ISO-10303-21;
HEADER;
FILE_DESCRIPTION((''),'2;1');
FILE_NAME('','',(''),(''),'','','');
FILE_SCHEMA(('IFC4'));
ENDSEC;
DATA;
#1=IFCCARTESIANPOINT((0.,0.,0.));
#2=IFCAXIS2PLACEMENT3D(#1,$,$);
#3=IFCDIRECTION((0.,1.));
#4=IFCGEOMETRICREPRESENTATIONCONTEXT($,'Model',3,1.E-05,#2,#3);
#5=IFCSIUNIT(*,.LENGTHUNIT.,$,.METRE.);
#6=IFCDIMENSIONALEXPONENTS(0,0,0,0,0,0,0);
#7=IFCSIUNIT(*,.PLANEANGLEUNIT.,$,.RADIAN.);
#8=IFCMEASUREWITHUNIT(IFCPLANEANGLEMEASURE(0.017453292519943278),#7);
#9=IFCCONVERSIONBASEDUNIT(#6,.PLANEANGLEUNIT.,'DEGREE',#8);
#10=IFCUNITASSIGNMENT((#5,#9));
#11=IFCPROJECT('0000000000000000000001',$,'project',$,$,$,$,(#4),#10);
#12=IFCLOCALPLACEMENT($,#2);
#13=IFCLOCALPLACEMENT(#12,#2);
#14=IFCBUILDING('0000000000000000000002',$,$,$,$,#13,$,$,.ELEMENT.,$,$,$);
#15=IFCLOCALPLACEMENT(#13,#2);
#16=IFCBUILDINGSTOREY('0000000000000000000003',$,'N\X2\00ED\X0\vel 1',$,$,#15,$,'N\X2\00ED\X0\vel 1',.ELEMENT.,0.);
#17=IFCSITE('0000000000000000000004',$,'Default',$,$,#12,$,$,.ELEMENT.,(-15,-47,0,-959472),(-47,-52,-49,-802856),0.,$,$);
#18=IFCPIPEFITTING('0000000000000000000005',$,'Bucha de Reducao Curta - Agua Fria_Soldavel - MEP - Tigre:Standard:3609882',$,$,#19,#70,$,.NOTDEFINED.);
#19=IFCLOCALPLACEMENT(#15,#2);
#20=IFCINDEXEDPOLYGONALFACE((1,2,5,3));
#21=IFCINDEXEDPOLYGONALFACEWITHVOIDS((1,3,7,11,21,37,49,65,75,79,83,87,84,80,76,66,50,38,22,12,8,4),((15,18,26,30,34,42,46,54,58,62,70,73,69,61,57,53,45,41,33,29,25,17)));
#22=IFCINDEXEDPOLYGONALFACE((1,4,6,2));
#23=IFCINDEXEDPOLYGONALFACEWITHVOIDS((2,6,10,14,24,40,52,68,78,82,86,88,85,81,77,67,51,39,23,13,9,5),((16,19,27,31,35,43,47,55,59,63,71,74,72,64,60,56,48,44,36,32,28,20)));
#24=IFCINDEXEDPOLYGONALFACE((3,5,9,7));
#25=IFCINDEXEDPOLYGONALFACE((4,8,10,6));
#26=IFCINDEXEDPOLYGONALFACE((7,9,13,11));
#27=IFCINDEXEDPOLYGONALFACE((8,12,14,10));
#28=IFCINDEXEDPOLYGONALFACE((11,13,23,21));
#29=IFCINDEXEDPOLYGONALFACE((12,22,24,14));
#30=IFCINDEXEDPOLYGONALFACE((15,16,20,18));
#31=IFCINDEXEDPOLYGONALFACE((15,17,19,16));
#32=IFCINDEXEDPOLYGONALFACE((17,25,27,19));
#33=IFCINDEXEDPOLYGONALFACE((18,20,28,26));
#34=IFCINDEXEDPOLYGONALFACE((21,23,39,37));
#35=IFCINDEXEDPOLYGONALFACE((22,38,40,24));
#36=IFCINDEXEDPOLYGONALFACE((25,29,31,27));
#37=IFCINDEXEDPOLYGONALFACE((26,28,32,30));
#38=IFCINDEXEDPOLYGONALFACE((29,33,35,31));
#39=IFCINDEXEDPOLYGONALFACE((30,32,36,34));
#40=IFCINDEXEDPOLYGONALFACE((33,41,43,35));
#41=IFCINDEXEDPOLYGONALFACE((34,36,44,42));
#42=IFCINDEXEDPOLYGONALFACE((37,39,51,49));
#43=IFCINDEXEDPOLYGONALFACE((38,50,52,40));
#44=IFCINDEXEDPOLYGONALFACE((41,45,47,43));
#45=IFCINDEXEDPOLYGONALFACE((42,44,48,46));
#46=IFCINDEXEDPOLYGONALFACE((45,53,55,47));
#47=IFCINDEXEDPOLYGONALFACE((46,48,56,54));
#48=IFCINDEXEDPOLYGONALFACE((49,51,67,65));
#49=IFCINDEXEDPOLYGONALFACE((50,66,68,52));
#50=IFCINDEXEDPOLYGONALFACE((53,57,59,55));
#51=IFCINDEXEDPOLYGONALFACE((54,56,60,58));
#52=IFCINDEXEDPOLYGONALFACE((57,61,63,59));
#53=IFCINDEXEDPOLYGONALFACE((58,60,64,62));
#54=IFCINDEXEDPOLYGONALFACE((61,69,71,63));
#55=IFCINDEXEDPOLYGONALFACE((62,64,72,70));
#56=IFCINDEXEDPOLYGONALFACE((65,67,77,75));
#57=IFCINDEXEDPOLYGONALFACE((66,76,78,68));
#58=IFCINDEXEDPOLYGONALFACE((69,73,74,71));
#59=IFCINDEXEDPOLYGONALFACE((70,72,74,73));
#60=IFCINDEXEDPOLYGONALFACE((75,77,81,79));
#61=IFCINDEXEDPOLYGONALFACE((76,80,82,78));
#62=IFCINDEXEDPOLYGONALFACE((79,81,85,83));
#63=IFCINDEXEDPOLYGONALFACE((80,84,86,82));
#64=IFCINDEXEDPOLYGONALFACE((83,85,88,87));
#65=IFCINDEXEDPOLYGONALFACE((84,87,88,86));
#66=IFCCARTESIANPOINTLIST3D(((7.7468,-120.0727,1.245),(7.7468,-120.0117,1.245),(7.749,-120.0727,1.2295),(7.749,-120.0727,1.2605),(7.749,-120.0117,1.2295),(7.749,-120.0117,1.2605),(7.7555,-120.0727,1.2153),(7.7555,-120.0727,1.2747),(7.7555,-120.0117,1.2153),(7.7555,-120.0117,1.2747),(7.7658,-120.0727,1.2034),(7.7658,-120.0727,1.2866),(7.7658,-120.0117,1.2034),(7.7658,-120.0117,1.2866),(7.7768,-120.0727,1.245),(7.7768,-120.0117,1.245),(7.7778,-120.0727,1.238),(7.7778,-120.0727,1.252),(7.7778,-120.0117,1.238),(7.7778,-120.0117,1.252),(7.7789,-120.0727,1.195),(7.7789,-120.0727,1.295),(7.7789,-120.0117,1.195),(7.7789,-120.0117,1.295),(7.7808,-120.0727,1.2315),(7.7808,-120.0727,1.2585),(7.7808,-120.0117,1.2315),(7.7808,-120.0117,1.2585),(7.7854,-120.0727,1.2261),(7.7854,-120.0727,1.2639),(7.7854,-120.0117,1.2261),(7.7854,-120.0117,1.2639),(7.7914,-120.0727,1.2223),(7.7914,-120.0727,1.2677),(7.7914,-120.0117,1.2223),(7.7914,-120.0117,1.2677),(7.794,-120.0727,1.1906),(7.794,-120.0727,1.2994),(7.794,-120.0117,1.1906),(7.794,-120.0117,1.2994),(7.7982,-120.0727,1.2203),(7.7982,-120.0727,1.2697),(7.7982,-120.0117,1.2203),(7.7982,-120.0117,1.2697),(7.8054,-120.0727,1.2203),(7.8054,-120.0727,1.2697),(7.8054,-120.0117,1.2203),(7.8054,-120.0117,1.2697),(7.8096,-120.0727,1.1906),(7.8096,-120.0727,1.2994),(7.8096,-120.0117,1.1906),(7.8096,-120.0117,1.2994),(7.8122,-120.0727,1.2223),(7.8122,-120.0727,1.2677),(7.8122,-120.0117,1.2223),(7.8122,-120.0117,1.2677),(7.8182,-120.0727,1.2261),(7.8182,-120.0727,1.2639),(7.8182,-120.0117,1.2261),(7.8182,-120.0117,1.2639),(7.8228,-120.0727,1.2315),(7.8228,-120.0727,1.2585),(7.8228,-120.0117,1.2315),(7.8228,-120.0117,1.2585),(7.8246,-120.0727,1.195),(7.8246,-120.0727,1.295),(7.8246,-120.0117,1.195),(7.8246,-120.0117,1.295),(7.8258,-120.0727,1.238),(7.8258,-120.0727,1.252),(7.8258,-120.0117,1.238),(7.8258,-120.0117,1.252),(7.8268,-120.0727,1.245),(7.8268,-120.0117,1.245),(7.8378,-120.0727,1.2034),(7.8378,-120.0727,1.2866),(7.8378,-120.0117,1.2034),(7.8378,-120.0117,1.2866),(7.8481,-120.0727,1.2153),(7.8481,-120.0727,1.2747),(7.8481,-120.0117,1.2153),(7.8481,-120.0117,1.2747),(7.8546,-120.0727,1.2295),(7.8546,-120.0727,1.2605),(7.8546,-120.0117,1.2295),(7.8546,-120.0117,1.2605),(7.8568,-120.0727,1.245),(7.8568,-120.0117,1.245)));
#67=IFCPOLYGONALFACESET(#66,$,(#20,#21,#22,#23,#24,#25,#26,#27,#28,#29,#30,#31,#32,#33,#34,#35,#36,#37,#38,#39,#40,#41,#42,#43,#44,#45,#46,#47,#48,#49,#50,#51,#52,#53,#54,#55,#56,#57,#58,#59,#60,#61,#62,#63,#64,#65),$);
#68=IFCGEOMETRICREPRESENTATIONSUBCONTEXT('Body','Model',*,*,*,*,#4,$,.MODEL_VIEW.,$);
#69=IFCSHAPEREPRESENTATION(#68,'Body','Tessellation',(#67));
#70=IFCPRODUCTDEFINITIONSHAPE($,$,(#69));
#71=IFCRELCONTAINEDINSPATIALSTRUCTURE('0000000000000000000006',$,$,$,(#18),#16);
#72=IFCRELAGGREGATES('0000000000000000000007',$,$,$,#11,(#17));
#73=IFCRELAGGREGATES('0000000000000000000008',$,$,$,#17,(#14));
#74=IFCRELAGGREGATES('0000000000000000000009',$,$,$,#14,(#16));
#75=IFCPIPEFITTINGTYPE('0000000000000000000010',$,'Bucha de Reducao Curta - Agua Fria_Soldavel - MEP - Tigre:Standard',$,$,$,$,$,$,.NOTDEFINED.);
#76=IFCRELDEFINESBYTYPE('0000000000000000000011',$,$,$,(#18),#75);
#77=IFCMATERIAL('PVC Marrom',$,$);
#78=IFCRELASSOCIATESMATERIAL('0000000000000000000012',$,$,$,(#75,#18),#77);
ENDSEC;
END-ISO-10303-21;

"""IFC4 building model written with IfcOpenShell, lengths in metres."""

from ifc_helpers import new_model, entity, si_unit, converted_unit, direction, frame, origin, place, context, subcontext, project, spatial, arc, indexed_curve, outline, extrude, source, transform, mapped, material, type_object, type_shapes, element, save


model = new_model("IFC4")

# Units and contexts
model_context = context("Model", 3, precision=1e-05, world=origin(), true_north=direction((0.0, 1.0)))
body_context = subcontext(model_context, "Body", "Model", "MODEL_VIEW")
ifc_project = project(units=[si_unit("LENGTHUNIT", "METRE"), converted_unit("PLANEANGLEUNIT", "DEGREE", entity("IfcPlaneAngleMeasure", 0.017453292519943278), si_unit("PLANEANGLEUNIT", "RADIAN"), dimensions=[0, 0, 0, 0, 0, 0, 0])], contexts=[model_context])

# Site, building, storey
site_placement = place(None, origin())
site = spatial("IfcSite", under=ifc_project, at=site_placement, Name="Default", CompositionType="ELEMENT", RefLatitude=(-15, -47, 0, -959472), RefLongitude=(-47, -52, -49, -802856), RefElevation=0.0)
building_placement = place(site_placement, origin())
building = spatial("IfcBuilding", under=site, at=building_placement, CompositionType="ELEMENT")
storey_placement = place(building_placement, origin())
storey = spatial("IfcBuildingStorey", under=building, at=storey_placement, Name="Nível 1", LongName="Nível 1", CompositionType="ELEMENT", Elevation=0.0)

# Pipe fitting
ifc_material_1 = material(Name="PVC Marrom")
pipe_fitting_type_1 = type_object("IfcPipeFittingType", Name="Bucha de Reducao Curta - Agua Fria_Soldavel - MEP - Tigre:Standard", PredefinedType="NOTDEFINED", material=ifc_material_1)
shared_shape_1 = source(origin(), body_context, "Body", "SweptSolid", [
    extrude(outline(indexed_curve([(-0.055, 0.0), (0.0, -0.055), (0.055, 0.0), (0.0, 0.055)], segments=[arc(1, 2, 3), arc(3, 4, 1)], self_intersect=False), holes=[indexed_curve([(-0.025, 0.0), (0.0, 0.025), (0.025, 0.0), (0.0, -0.025)], segments=[arc(1, 2, 3), arc(3, 4, 1)], self_intersect=False)]), frame((0.0, 0.0, 0.0), z_axis=(1.0, 0.0, 0.0), x_axis=(0.0, 1.0, 0.0)), (0.0, 0.0, 1.0), 0.061),
])
type_shapes(pipe_fitting_type_1, [shared_shape_1])
pipe_fitting_placement = place(storey_placement, frame((7.8018, -120.0727, 1.245), z_axis=(0.0, 0.0, 1.0), x_axis=(0.0, 1.0, 0.0)))
element("IfcPipeFitting", 1, at=pipe_fitting_placement, inside=storey, type_object=pipe_fitting_type_1, material=ifc_material_1, Name="Bucha de Reducao Curta - Agua Fria_Soldavel - MEP - Tigre:Standard:3609882", PredefinedType="NOTDEFINED", context=body_context, shape_type="MappedRepresentation", body=[
    mapped(shared_shape_1, transform((0.0, 0.0, 0.0), scale=1.0)),
])

save(model, "model.ifc")
